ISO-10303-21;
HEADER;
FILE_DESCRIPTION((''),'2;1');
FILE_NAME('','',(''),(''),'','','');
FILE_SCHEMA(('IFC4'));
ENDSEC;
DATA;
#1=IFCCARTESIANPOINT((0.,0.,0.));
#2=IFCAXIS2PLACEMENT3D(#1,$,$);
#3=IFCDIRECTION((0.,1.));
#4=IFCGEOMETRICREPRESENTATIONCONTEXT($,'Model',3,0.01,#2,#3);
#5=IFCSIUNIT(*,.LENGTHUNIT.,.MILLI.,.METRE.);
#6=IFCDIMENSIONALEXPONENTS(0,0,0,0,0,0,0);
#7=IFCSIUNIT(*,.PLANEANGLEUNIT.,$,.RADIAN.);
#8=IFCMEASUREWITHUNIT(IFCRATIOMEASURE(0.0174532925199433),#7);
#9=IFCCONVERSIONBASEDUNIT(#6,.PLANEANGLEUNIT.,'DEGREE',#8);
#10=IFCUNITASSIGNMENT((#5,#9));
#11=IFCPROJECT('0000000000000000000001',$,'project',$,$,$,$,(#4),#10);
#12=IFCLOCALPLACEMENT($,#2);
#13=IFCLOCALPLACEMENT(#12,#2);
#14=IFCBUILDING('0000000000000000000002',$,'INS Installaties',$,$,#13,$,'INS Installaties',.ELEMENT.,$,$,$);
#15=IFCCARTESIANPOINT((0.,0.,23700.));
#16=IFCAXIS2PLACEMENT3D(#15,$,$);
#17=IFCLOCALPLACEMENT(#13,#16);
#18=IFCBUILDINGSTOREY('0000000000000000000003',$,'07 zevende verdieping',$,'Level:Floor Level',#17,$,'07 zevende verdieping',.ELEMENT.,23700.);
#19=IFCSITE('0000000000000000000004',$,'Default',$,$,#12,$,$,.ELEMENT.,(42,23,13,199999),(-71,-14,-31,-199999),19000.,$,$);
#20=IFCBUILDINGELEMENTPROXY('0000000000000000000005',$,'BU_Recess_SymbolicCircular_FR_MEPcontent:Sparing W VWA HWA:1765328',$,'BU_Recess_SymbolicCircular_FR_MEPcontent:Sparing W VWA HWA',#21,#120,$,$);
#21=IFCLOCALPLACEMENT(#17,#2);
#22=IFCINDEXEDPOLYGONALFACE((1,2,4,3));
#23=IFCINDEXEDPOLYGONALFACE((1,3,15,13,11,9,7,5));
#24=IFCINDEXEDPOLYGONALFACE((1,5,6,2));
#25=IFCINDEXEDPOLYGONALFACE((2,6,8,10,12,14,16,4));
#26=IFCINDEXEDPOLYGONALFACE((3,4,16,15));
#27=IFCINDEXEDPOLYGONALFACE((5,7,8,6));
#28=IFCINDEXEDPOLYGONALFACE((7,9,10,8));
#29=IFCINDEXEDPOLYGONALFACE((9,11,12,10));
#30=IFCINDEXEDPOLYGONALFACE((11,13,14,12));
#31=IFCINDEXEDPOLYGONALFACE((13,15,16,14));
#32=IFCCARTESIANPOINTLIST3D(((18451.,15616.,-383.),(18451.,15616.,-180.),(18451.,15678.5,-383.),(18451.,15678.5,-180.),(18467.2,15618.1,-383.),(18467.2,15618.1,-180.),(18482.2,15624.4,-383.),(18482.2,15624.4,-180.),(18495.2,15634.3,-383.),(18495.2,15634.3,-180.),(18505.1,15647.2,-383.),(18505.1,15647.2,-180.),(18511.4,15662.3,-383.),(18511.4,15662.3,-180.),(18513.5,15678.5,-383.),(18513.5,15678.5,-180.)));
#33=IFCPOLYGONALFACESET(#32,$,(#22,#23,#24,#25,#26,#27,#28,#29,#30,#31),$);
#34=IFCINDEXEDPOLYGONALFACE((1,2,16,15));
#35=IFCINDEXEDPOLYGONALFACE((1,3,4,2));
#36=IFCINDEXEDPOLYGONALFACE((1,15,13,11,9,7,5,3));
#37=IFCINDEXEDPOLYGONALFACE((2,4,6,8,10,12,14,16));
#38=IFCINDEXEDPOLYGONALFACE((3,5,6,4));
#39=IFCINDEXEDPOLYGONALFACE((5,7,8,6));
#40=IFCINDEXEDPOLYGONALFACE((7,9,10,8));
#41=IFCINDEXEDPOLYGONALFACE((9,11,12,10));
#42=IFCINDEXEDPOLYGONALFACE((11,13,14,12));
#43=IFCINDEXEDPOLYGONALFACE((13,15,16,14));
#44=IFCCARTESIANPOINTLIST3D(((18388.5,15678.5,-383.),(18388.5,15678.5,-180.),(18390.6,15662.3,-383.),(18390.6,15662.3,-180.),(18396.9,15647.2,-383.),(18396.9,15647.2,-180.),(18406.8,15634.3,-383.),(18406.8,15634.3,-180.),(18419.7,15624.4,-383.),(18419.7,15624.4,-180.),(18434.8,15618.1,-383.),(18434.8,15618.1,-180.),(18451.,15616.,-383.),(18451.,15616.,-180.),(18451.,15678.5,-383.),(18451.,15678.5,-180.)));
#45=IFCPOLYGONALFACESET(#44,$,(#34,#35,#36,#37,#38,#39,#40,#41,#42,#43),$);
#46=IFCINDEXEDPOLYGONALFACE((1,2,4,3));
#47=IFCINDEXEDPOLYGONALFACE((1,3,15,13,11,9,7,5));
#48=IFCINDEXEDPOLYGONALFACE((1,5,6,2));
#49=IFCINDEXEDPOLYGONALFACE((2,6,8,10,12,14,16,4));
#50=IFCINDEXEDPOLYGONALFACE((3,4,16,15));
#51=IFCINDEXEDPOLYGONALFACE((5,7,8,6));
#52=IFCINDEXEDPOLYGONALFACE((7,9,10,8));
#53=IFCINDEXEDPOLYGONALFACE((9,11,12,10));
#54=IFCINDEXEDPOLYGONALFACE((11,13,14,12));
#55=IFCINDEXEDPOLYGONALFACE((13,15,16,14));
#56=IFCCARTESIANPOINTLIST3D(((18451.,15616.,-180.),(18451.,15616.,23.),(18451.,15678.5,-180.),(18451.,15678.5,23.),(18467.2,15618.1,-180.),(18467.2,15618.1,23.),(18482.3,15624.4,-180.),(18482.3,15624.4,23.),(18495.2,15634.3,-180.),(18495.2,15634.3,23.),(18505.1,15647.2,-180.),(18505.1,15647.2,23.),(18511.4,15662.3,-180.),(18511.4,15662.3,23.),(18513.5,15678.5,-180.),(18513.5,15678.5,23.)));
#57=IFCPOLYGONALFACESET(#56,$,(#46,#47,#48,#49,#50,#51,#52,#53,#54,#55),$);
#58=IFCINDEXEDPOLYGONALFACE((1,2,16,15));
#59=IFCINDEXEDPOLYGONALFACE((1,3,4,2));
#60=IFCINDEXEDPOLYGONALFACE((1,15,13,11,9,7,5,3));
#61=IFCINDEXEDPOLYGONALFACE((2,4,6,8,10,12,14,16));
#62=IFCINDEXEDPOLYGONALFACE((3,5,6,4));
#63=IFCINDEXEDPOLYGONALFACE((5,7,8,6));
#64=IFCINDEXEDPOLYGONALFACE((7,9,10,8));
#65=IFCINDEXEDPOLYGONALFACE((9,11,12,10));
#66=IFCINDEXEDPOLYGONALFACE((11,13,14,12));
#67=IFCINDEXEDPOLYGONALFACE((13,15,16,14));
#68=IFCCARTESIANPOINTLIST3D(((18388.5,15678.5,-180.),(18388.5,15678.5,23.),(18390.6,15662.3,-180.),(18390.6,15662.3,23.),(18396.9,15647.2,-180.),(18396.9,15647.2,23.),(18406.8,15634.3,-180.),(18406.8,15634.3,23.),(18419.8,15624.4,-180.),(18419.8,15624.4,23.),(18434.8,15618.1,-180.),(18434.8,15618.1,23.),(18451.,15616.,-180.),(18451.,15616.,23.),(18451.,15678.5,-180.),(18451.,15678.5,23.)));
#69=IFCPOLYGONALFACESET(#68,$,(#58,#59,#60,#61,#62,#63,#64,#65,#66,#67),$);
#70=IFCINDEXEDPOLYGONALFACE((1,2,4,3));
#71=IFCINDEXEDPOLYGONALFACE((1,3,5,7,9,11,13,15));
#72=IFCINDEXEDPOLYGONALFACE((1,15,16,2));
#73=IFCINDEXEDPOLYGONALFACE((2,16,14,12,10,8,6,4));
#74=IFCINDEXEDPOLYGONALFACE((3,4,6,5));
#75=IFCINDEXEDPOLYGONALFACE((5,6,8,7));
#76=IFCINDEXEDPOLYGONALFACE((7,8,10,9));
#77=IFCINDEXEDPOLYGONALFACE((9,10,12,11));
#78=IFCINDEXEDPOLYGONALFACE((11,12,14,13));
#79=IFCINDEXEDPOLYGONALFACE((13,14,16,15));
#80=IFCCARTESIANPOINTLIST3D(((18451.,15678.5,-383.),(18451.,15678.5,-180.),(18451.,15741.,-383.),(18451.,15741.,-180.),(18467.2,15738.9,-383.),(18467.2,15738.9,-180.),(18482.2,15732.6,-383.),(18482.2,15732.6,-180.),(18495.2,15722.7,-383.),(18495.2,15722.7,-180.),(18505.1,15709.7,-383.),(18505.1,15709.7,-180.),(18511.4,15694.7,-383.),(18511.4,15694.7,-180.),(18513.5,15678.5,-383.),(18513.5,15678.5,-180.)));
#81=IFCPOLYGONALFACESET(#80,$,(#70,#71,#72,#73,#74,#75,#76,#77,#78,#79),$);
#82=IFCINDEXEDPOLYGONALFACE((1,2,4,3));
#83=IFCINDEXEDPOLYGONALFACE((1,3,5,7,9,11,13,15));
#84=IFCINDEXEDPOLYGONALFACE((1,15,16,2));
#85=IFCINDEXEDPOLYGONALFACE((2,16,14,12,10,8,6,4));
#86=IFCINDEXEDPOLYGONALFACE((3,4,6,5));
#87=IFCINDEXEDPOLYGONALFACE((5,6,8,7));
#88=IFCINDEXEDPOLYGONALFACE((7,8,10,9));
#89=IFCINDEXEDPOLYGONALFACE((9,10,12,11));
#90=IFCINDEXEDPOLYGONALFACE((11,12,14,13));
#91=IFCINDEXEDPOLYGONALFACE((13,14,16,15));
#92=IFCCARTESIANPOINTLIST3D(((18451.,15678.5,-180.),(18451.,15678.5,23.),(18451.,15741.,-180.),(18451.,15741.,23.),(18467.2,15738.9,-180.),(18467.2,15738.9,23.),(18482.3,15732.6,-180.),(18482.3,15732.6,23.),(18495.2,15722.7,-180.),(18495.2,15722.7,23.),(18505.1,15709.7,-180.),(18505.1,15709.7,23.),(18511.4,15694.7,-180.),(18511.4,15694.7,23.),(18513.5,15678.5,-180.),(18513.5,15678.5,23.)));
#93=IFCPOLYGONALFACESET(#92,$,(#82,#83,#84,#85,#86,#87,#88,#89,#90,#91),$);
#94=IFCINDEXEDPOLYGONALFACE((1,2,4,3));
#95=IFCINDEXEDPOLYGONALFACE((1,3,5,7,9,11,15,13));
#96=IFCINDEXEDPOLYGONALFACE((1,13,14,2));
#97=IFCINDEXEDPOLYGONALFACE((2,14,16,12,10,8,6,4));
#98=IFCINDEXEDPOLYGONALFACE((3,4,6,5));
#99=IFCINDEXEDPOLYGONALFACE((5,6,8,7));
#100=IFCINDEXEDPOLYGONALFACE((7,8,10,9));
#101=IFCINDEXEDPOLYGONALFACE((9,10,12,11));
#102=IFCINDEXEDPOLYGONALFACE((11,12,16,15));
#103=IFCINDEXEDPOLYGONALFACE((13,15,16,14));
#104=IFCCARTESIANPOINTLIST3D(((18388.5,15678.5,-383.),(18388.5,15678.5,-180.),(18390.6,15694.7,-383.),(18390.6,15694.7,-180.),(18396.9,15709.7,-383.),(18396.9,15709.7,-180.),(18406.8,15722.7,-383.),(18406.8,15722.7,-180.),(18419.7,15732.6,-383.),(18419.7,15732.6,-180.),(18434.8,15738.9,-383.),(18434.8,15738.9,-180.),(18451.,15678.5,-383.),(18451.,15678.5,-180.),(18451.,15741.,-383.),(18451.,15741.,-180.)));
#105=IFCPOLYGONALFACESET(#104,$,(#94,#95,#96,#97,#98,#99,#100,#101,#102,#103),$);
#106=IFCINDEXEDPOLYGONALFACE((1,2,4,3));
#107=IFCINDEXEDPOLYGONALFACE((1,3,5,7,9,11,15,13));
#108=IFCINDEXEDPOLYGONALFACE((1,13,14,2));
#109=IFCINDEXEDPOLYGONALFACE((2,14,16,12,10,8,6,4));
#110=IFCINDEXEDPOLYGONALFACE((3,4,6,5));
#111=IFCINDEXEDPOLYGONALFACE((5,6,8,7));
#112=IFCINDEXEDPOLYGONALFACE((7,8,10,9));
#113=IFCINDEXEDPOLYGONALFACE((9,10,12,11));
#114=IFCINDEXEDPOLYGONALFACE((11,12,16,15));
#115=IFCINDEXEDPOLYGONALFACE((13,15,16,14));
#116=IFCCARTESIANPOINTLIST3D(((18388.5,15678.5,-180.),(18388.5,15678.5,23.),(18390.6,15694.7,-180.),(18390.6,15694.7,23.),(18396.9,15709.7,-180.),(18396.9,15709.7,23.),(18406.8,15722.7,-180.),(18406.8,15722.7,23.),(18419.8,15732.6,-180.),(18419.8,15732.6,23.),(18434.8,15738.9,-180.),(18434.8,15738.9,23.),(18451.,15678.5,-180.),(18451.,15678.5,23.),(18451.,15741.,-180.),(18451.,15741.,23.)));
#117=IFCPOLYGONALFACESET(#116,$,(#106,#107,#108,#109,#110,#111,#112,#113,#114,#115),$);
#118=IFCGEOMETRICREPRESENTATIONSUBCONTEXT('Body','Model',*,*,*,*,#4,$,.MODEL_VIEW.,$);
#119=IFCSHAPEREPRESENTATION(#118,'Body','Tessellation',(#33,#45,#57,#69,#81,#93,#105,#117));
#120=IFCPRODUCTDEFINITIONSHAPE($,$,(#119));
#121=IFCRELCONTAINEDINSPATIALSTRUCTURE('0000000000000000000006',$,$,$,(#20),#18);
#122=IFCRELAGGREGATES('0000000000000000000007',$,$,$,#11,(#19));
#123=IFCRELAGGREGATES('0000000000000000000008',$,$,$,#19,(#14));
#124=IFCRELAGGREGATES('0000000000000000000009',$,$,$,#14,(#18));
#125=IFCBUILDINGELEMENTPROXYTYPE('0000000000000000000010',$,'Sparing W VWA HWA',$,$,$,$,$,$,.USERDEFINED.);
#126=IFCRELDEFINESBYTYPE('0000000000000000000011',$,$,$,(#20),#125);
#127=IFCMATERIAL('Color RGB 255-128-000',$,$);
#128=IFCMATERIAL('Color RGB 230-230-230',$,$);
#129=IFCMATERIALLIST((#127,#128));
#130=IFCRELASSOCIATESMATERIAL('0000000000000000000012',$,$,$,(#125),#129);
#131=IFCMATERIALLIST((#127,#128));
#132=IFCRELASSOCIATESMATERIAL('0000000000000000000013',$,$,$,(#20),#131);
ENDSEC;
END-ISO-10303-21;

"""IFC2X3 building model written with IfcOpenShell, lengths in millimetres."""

from ifc_helpers import new_model, entity, si_unit, converted_unit, direction, frame, frame_2d, origin, place, context, subcontext, project, spatial, polyline, circle_curve, parameter, trimmed, segment, composite_curve, outline, extrude, source, transform, mapped, material, material_list, type_object, type_shapes, element, save


model = new_model("IFC2X3")

# Units and contexts
model_context = context("Model", 3, precision=0.01, world=origin(), true_north=direction((0.0, 1.0)))
body_context = subcontext(model_context, "Body", "Model", "MODEL_VIEW")
ifc_project = project(units=[si_unit("LENGTHUNIT", "METRE", prefix="MILLI"), converted_unit("PLANEANGLEUNIT", "DEGREE", entity("IfcRatioMeasure", 0.0174532925199433), si_unit("PLANEANGLEUNIT", "RADIAN"), dimensions=[0, 0, 0, 0, 0, 0, 0])], contexts=[model_context])

# Site, building, storey
site_placement = place(None, origin())
site = spatial("IfcSite", under=ifc_project, at=site_placement, Name="Default", CompositionType="ELEMENT", RefLatitude=(42, 23, 13, 199999), RefLongitude=(-71, -14, -31, -199999), RefElevation=19000.0)
building_placement = place(site_placement, origin())
building = spatial("IfcBuilding", under=site, at=building_placement, Name="INS Installaties", LongName="INS Installaties", CompositionType="ELEMENT")
storey_placement = place(building_placement, frame((0.0, 0.0, 23700.0)))
storey = spatial("IfcBuildingStorey", under=building, at=storey_placement, Name="07 zevende verdieping", ObjectType="Level:Floor Level", LongName="07 zevende verdieping", CompositionType="ELEMENT", Elevation=23700.0)

# Building element proxy
ifc_material_1 = material(Name="Color RGB 255-128-000")
ifc_material_2 = material(Name="Color RGB 230-230-230")
ifc_material_list_1 = material_list([ifc_material_1, ifc_material_2])
building_element_proxy_type_1 = type_object("IfcBuildingElementProxyType", Name="Sparing W VWA HWA", PredefinedType="USERDEFINED", material=ifc_material_list_1)
shared_shape_1 = source(origin(), body_context, "Body", "SweptSolid", [
    extrude(outline(composite_curve([segment(polyline([(-41.7, -20.8), (20.8, -20.8)]), True, "CONTINUOUS"), segment(polyline([(20.8, -20.8), (20.8, 41.7)]), True, "CONTINUOUS"), segment(trimmed(circle_curve(frame_2d((20.8, -20.8), x_axis=(1.0, 0.0)), 62.5), [parameter(90.0)], [parameter(180.0)], True, "PARAMETER"), True, "CONTINUOUS")], self_intersect=False)), frame((20.8, -20.8, -403.0), z_axis=(0.0, 0.0, 1.0), x_axis=(-1.0, 0.0, 0.0)), (0.0, 0.0, 1.0), 203.0),
    extrude(outline(composite_curve([segment(trimmed(circle_curve(frame_2d((20.8, 20.8), x_axis=(1.0, 0.0)), 62.5), [parameter(180.0)], [parameter(270.0)], True, "PARAMETER"), True, "CONTINUOUS"), segment(polyline([(20.8, -41.7), (20.8, 20.8)]), True, "CONTINUOUS"), segment(polyline([(20.8, 20.8), (-41.7, 20.8)]), True, "CONTINUOUS")], self_intersect=False)), frame((-20.8, -20.8, -403.0)), (0.0, 0.0, 1.0), 203.0),
    extrude(outline(composite_curve([segment(polyline([(-41.7, -20.8), (20.8, -20.8)]), True, "CONTINUOUS"), segment(polyline([(20.8, -20.8), (20.8, 41.7)]), True, "CONTINUOUS"), segment(trimmed(circle_curve(frame_2d((20.8, -20.8), x_axis=(1.0, 0.0)), 62.5), [parameter(90.0)], [parameter(180.0)], True, "PARAMETER"), True, "CONTINUOUS")], self_intersect=False)), frame((20.8, -20.8, -200.0), z_axis=(0.0, 0.0, 1.0), x_axis=(-1.0, 0.0, 0.0)), (0.0, 0.0, 1.0), 203.0),
    extrude(outline(composite_curve([segment(trimmed(circle_curve(frame_2d((20.8, 20.8), x_axis=(1.0, 0.0)), 62.5), [parameter(180.0)], [parameter(270.0)], True, "PARAMETER"), True, "CONTINUOUS"), segment(polyline([(20.8, -41.7), (20.8, 20.8)]), True, "CONTINUOUS"), segment(polyline([(20.8, 20.8), (-41.7, 20.8)]), True, "CONTINUOUS")], self_intersect=False)), frame((-20.8, -20.8, -200.0)), (0.0, 0.0, 1.0), 203.0),
    extrude(outline(composite_curve([segment(trimmed(circle_curve(frame_2d((20.8, 20.8), x_axis=(1.0, 0.0)), 62.5), [parameter(180.0)], [parameter(270.0)], True, "PARAMETER"), True, "CONTINUOUS"), segment(polyline([(20.8, -41.7), (20.8, 20.8)]), True, "CONTINUOUS"), segment(polyline([(20.8, 20.8), (-41.7, 20.8)]), True, "CONTINUOUS")], self_intersect=False)), frame((20.8, 20.8, -403.0), z_axis=(0.0, 0.0, 1.0), x_axis=(-1.0, 0.0, 0.0)), (0.0, 0.0, 1.0), 203.0),
    extrude(outline(composite_curve([segment(trimmed(circle_curve(frame_2d((20.8, 20.8), x_axis=(1.0, 0.0)), 62.5), [parameter(180.0)], [parameter(270.0)], True, "PARAMETER"), True, "CONTINUOUS"), segment(polyline([(20.8, -41.7), (20.8, 20.8)]), True, "CONTINUOUS"), segment(polyline([(20.8, 20.8), (-41.7, 20.8)]), True, "CONTINUOUS")], self_intersect=False)), frame((20.8, 20.8, -200.0), z_axis=(0.0, 0.0, 1.0), x_axis=(-1.0, 0.0, 0.0)), (0.0, 0.0, 1.0), 203.0),
    extrude(outline(composite_curve([segment(polyline([(-41.7, -20.8), (20.8, -20.8)]), True, "CONTINUOUS"), segment(polyline([(20.8, -20.8), (20.8, 41.7)]), True, "CONTINUOUS"), segment(trimmed(circle_curve(frame_2d((20.8, -20.8), x_axis=(1.0, 0.0)), 62.5), [parameter(90.0)], [parameter(180.0)], True, "PARAMETER"), True, "CONTINUOUS")], self_intersect=False)), frame((-20.8, 20.8, -403.0)), (0.0, 0.0, 1.0), 203.0),
    extrude(outline(composite_curve([segment(polyline([(-41.7, -20.8), (20.8, -20.8)]), True, "CONTINUOUS"), segment(polyline([(20.8, -20.8), (20.8, 41.7)]), True, "CONTINUOUS"), segment(trimmed(circle_curve(frame_2d((20.8, -20.8), x_axis=(1.0, 0.0)), 62.5), [parameter(90.0)], [parameter(180.0)], True, "PARAMETER"), True, "CONTINUOUS")], self_intersect=False)), frame((-20.8, 20.8, -200.0)), (0.0, 0.0, 1.0), 203.0),
])
type_shapes(building_element_proxy_type_1, [shared_shape_1])
ifc_material_list_2 = material_list([ifc_material_1, ifc_material_2])
proxy_1_placement = place(storey_placement, frame((18451.0, 15678.5, 20.0)))
element("IfcBuildingElementProxy", 1, at=proxy_1_placement, inside=storey, type_object=building_element_proxy_type_1, material=ifc_material_list_2, Name="BU_Recess_SymbolicCircular_FR_MEPcontent:Sparing W VWA HWA:1765328", ObjectType="BU_Recess_SymbolicCircular_FR_MEPcontent:Sparing W VWA HWA", context=body_context, shape_type="MappedRepresentation", body=[
    mapped(shared_shape_1, transform((0.0, 0.0, 0.0), scale=1.0)),
])

save(model, "model.ifc")
